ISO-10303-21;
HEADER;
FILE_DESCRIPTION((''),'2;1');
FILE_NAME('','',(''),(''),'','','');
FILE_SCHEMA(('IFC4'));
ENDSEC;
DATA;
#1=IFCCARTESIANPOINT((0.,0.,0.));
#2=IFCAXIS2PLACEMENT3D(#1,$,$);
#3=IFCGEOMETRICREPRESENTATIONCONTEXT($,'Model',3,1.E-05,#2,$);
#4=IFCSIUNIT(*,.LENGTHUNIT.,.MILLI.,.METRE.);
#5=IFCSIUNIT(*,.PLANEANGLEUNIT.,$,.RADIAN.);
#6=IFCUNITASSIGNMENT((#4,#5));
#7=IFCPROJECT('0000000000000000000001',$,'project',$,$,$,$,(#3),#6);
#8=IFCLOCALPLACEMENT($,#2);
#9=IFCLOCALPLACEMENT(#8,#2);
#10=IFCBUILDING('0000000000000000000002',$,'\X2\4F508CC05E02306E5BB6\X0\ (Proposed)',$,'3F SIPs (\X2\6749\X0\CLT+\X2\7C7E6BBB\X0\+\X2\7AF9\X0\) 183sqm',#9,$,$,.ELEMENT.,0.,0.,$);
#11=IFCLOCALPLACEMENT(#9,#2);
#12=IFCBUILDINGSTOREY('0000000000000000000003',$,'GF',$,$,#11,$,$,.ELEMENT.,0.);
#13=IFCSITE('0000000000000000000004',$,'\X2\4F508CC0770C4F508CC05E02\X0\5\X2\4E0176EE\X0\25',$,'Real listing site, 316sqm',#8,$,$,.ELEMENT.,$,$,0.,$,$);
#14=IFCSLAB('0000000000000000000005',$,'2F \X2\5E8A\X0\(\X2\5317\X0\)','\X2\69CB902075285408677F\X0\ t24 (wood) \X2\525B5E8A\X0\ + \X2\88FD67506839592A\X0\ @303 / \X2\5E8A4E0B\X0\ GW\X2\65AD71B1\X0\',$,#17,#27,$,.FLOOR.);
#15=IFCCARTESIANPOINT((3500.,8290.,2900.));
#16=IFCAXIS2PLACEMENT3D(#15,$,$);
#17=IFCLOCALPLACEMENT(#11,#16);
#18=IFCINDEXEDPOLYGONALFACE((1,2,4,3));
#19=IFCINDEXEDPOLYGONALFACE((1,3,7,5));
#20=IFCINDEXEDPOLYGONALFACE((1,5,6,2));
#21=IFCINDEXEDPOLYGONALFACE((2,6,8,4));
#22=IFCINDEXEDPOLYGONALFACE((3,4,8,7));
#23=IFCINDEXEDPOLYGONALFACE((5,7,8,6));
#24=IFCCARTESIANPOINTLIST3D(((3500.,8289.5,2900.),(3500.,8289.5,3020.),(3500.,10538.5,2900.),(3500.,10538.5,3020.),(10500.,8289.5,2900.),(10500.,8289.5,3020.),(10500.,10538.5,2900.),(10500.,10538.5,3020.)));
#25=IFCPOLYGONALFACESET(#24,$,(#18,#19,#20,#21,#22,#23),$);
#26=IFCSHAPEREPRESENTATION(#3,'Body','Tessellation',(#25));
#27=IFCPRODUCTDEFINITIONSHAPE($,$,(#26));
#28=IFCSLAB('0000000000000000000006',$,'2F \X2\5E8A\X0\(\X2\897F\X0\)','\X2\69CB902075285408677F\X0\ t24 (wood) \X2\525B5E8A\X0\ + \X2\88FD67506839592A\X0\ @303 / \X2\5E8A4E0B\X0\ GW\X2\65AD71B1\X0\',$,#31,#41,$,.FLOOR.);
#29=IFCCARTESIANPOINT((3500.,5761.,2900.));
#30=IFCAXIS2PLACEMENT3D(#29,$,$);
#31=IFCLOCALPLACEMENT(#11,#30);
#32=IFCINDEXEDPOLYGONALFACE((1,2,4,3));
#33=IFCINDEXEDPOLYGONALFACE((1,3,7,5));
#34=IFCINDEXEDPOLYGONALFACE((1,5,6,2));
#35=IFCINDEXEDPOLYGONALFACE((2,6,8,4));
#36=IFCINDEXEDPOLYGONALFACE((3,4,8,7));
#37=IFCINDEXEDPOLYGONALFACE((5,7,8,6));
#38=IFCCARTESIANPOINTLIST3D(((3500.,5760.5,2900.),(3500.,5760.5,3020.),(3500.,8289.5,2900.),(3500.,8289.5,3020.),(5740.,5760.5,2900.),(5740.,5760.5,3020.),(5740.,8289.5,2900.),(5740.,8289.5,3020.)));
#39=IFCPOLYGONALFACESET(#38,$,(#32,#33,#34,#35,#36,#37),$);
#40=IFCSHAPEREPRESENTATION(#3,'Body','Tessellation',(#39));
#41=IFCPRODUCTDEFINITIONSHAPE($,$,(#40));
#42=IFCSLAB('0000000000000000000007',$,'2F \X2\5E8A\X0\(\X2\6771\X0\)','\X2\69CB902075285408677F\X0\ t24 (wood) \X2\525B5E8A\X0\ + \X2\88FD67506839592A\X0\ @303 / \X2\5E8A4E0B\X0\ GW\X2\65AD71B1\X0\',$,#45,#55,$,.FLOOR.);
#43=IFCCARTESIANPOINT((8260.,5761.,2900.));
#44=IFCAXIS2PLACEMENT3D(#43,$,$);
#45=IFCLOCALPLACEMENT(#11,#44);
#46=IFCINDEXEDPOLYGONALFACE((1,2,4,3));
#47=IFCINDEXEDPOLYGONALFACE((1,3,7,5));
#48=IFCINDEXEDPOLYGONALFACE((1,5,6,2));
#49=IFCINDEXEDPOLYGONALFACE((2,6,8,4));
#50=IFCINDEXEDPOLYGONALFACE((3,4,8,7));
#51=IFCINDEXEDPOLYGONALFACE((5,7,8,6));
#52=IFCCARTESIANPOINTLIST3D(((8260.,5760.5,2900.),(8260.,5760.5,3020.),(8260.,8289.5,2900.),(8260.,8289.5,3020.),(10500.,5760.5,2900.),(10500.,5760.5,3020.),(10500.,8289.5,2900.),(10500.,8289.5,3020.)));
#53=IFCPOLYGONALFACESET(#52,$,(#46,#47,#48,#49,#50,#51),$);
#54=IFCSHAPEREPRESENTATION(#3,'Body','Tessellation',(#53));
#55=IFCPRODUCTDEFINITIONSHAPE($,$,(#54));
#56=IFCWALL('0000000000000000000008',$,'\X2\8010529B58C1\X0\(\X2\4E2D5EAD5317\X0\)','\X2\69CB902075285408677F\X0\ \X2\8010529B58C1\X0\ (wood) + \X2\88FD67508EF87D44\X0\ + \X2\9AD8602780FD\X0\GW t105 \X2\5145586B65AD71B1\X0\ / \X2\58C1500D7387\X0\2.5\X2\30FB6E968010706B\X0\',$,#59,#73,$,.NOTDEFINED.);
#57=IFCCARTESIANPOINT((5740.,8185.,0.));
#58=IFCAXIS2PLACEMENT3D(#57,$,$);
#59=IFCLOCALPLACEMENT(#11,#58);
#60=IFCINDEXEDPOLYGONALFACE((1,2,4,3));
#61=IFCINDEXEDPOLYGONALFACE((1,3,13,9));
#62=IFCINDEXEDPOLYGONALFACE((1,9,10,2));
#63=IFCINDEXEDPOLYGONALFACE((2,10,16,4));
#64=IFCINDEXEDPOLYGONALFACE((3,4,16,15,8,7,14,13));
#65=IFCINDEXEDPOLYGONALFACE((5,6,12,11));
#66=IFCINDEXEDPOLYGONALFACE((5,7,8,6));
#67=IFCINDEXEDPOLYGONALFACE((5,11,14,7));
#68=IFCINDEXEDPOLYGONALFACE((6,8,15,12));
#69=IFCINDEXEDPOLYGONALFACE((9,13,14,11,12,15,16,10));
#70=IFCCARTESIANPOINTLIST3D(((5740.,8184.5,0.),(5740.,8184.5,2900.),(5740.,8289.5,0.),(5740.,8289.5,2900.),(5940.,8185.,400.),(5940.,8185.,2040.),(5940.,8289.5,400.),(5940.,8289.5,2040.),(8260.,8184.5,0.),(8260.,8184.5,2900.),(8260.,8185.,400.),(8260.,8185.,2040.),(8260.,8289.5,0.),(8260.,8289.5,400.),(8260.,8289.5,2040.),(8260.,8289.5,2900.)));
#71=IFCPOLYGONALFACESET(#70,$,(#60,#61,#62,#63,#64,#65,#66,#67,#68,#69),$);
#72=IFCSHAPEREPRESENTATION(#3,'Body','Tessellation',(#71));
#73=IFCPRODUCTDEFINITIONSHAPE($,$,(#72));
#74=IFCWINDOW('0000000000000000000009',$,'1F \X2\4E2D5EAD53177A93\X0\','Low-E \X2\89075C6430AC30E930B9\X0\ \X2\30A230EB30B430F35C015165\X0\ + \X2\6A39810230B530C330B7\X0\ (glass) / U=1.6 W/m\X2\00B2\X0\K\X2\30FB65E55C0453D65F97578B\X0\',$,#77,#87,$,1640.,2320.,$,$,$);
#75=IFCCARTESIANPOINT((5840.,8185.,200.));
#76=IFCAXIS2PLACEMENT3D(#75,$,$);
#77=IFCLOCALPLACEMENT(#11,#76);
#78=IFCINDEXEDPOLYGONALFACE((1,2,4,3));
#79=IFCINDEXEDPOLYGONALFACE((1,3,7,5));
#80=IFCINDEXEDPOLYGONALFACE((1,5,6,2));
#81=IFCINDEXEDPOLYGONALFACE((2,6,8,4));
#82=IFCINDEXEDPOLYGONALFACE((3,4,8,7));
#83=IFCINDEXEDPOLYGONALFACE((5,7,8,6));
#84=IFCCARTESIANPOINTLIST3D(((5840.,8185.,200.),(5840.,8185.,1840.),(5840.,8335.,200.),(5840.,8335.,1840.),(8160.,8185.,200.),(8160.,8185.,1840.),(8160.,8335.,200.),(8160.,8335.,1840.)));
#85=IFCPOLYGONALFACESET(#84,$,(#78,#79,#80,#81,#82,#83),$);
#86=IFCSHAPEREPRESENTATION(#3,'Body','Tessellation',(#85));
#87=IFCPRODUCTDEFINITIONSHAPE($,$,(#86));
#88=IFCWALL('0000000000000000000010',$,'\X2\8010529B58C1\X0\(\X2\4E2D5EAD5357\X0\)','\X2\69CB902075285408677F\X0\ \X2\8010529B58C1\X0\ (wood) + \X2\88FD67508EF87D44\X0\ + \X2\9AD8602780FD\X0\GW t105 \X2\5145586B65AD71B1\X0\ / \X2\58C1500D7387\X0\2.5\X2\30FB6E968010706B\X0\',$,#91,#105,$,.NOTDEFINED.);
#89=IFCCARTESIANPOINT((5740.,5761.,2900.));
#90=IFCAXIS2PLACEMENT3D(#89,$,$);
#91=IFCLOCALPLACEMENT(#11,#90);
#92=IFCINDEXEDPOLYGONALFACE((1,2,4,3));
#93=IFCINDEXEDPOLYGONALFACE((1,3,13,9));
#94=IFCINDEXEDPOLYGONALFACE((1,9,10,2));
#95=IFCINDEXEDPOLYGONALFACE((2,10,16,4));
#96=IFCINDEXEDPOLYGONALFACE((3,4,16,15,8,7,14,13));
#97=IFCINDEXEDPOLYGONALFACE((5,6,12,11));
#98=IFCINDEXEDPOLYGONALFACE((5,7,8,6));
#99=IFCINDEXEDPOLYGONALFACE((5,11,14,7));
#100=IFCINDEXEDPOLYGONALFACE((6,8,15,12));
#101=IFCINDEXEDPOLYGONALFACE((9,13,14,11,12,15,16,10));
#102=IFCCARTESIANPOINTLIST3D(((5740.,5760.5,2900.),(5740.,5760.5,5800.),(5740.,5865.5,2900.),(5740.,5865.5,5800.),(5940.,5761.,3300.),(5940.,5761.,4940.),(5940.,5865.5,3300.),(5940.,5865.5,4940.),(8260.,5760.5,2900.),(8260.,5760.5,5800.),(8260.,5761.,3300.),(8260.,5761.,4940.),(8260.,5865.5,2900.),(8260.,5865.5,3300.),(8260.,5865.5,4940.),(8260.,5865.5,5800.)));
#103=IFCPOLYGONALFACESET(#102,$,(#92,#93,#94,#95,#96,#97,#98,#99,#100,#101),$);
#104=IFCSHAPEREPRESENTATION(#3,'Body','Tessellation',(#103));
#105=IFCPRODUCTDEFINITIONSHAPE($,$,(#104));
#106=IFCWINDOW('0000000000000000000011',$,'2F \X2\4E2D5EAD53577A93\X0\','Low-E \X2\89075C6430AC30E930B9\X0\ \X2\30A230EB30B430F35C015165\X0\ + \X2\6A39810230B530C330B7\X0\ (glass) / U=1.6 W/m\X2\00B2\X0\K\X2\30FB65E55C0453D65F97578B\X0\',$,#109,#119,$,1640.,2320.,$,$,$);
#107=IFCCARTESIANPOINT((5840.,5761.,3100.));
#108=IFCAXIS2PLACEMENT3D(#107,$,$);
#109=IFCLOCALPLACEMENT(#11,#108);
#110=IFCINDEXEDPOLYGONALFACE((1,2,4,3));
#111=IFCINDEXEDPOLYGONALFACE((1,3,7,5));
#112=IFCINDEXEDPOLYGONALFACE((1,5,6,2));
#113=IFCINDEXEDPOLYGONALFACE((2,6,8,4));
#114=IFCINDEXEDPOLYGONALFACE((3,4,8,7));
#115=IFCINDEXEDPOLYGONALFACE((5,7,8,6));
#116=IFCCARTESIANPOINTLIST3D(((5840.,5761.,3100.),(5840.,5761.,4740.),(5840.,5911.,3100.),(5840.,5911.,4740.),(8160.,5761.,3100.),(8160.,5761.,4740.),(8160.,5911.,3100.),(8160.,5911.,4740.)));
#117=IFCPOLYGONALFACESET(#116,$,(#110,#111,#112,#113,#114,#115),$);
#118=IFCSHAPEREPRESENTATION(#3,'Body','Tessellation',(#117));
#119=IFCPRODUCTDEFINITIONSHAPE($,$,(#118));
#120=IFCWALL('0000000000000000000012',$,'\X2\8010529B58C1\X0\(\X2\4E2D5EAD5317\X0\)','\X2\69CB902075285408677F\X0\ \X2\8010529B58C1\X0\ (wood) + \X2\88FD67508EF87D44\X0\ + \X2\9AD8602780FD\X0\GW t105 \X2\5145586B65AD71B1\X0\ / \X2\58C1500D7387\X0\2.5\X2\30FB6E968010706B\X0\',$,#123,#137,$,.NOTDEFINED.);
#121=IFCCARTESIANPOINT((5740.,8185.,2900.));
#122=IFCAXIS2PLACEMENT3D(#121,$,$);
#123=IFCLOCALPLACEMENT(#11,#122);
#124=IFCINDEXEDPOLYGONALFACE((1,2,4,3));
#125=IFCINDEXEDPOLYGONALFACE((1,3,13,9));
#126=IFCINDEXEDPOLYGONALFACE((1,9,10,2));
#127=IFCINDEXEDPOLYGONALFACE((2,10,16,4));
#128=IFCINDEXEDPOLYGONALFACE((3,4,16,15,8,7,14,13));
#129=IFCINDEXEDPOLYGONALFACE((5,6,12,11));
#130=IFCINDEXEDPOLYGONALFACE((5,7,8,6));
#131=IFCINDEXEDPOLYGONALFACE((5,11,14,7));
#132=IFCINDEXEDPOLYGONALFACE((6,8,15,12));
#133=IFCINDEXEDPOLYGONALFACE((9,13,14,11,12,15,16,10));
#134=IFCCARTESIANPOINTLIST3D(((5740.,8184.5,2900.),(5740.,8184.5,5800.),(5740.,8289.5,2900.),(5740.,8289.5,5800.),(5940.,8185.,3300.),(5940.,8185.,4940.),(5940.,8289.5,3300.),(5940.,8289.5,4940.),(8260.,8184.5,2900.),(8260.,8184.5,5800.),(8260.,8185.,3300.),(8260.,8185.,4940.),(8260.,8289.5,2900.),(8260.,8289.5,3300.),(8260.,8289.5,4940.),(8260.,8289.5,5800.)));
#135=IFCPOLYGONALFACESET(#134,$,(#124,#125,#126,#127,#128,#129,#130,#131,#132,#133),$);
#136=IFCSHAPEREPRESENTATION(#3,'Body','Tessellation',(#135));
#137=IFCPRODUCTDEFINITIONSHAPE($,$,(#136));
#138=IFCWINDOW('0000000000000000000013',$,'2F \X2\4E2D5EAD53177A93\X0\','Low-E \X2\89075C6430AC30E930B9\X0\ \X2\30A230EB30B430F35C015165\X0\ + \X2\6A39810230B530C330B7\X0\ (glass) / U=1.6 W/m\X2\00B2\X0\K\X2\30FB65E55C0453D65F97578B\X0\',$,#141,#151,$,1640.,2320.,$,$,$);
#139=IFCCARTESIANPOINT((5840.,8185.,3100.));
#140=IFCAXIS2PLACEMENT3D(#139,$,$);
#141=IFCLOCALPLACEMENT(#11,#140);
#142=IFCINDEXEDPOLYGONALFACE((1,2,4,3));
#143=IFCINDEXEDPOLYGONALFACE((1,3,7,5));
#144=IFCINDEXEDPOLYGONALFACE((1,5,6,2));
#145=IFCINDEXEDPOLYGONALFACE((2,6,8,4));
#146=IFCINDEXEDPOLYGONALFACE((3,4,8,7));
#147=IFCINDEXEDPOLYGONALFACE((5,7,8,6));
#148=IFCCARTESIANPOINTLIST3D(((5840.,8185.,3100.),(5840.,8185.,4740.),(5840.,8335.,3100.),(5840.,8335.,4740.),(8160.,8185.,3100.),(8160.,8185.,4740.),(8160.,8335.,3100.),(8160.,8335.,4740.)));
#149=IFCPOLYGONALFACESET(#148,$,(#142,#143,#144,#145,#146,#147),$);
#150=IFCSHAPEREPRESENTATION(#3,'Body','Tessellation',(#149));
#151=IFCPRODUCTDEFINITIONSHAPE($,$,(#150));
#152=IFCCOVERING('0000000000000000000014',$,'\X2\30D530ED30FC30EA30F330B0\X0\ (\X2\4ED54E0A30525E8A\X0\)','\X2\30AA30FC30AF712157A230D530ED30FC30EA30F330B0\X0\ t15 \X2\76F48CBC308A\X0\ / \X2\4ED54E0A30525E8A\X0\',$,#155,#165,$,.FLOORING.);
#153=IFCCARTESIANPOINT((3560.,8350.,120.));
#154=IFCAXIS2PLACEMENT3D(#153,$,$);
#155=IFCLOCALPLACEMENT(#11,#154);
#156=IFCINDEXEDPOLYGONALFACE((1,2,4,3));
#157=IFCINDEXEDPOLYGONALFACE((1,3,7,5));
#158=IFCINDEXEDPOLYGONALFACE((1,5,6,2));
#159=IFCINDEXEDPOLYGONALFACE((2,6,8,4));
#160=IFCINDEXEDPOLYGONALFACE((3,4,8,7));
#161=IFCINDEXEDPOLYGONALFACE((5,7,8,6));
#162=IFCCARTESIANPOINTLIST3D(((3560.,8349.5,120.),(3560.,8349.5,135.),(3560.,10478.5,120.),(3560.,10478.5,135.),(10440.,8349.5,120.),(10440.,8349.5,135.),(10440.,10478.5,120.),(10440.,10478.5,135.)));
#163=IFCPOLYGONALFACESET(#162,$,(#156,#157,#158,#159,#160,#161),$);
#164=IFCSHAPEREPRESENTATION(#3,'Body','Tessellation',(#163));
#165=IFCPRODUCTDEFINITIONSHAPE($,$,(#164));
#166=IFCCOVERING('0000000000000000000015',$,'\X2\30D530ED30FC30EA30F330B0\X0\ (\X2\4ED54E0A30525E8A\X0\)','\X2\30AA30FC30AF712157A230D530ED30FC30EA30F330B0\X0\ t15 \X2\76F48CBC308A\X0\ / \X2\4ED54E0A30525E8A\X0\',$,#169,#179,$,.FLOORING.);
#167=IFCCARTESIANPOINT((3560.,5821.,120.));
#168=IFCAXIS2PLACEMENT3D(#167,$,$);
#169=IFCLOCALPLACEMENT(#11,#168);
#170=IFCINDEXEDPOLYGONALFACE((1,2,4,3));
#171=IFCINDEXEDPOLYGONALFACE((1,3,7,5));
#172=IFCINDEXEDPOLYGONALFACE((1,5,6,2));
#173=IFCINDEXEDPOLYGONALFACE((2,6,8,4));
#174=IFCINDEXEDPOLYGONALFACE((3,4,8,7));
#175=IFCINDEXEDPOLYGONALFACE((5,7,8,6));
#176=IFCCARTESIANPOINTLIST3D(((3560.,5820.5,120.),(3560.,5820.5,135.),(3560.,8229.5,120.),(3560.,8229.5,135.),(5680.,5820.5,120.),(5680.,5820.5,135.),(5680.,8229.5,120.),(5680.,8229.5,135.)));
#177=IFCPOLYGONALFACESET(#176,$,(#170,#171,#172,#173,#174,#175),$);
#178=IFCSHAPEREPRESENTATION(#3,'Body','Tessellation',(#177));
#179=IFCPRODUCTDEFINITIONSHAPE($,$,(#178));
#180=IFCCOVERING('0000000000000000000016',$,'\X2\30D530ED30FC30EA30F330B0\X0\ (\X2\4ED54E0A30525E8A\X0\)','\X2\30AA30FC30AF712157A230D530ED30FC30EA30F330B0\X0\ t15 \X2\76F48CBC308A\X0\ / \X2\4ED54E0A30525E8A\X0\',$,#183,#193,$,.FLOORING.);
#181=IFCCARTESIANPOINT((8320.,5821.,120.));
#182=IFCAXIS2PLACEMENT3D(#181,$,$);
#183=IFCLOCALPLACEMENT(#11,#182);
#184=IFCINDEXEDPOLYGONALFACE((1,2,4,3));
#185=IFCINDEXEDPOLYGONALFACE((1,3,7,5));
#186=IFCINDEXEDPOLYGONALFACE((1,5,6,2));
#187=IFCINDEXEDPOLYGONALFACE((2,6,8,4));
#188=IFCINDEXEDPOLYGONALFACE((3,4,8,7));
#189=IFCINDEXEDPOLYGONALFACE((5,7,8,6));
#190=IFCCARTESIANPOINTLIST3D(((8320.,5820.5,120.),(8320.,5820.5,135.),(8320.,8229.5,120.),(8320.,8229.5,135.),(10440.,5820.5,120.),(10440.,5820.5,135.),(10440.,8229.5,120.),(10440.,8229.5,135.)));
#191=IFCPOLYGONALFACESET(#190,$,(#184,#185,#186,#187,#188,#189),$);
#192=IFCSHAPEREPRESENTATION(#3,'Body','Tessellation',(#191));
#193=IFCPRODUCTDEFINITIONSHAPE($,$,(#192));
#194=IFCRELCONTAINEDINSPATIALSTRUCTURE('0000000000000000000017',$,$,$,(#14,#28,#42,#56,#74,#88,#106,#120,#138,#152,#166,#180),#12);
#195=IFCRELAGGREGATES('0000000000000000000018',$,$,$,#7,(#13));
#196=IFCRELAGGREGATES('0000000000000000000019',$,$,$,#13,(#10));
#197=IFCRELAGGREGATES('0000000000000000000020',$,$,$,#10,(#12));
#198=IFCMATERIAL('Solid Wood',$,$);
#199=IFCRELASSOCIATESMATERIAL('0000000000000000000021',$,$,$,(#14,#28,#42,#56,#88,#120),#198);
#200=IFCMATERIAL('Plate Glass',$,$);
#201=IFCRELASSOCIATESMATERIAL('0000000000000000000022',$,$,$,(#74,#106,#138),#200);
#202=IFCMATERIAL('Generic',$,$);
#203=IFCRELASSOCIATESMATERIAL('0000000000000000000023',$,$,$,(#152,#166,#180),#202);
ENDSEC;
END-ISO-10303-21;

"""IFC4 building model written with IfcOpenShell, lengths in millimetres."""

from ifc_helpers import new_model, si_unit, frame, frame_2d, origin, place, context, project, spatial, rectangle, extrude, material, element, fill, save


model = new_model("IFC4")

# Units and contexts
model_context = context("Model", 3, precision=1e-05, world=origin())
ifc_project = project(units=[si_unit("LENGTHUNIT", "METRE", prefix="MILLI"), si_unit("PLANEANGLEUNIT", "RADIAN")], contexts=[model_context])

# Site, building, storey
site_placement = place(None, origin())
site = spatial("IfcSite", under=ifc_project, at=site_placement, Name="佐賀県佐賀市5丁目25", ObjectType="Real listing site, 316sqm", CompositionType="ELEMENT", RefElevation=0.0)
building_placement = place(site_placement, origin())
building = spatial("IfcBuilding", under=site, at=building_placement, Name="佐賀市の家 (Proposed)", ObjectType="3F SIPs (杉CLT+籾殻+竹) 183sqm", CompositionType="ELEMENT", ElevationOfRefHeight=0.0, ElevationOfTerrain=0.0)
storey_placement = place(building_placement, origin())
storey = spatial("IfcBuildingStorey", under=building, at=storey_placement, Name="GF", CompositionType="ELEMENT", Elevation=0.0)

# Slabs
ifc_material_1 = material(Name="Solid Wood")
slab_1_placement = place(storey_placement, frame((3500.0, 8290.0, 2900.0)))
element("IfcSlab", 1, at=slab_1_placement, inside=storey, material=ifc_material_1, Name="2F 床(北)", Description="構造用合板 t24 (wood) 剛床 + 製材根太 @303 / 床下 GW断熱", PredefinedType="FLOOR", context=model_context, shape_type="SweptSolid", body=[
    extrude(rectangle(XDim=7000.0, YDim=2249.0, at=frame_2d((3500.0, 1124.0))), frame((3500.0, 8290.0, 2900.0)), (0.0, 0.0, 1.0), 120.0),
])
slab_2_placement = place(storey_placement, frame((3500.0, 5761.0, 2900.0)))
element("IfcSlab", 2, at=slab_2_placement, inside=storey, material=ifc_material_1, Name="2F 床(西)", Description="構造用合板 t24 (wood) 剛床 + 製材根太 @303 / 床下 GW断熱", PredefinedType="FLOOR", context=model_context, shape_type="SweptSolid", body=[
    extrude(rectangle(XDim=2240.0, YDim=2529.0, at=frame_2d((1120.0, 1264.0))), frame((3500.0, 5761.0, 2900.0)), (0.0, 0.0, 1.0), 120.0),
])
slab_3_placement = place(storey_placement, frame((8260.0, 5761.0, 2900.0)))
element("IfcSlab", 3, at=slab_3_placement, inside=storey, material=ifc_material_1, Name="2F 床(東)", Description="構造用合板 t24 (wood) 剛床 + 製材根太 @303 / 床下 GW断熱", PredefinedType="FLOOR", context=model_context, shape_type="SweptSolid", body=[
    extrude(rectangle(XDim=2240.0, YDim=2529.0, at=frame_2d((1120.0, 1264.0))), frame((8260.0, 5761.0, 2900.0)), (0.0, 0.0, 1.0), 120.0),
])

# Wall, opening, window
wall_1_placement = place(storey_placement, frame((5740.0, 8185.0, 0.0)))
wall_1 = element("IfcWall", 4, at=wall_1_placement, inside=storey, material=ifc_material_1, Name="耐力壁(中庭北)", Description="構造用合板 耐力壁 (wood) + 製材軸組 + 高性能GW t105 充填断熱 / 壁倍率2.5・準耐火", PredefinedType="NOTDEFINED", context=model_context, shape_type="SweptSolid", body=[
    extrude(rectangle(XDim=2520.0, YDim=105.0, at=frame_2d((1260.0, 52.0))), frame((5740.0, 8185.0, 0.0)), (0.0, 0.0, 1.0), 2900.0),
])
opening_1_placement = place(storey_placement, frame((5840.0, 8185.0, 200.0)))
opening_1 = element("IfcOpeningElement", 5, at=opening_1_placement, cuts=wall_1, PredefinedType="NOTDEFINED", context=model_context, shape_type="SweptSolid", body=[
    extrude(rectangle(XDim=2320.0, YDim=150.0, at=frame_2d((1160.0, 75.0))), frame((5840.0, 8185.0, 200.0)), (0.0, 0.0, 1.0), 1640.0),
])
ifc_material_2 = material(Name="Plate Glass")
window_1_placement = place(storey_placement, frame((5840.0, 8185.0, 200.0)))
window_1 = element("IfcWindow", 6, at=window_1_placement, inside=storey, material=ifc_material_2, Name="1F 中庭北窓", Description="Low-E 複層ガラス アルゴン封入 + 樹脂サッシ (glass) / U=1.6 W/m²K・日射取得型", OverallHeight=1640.0, OverallWidth=2320.0, context=model_context, shape_type="SweptSolid", body=[
    extrude(rectangle(XDim=2320.0, YDim=150.0, at=frame_2d((1160.0, 75.0))), frame((5840.0, 8185.0, 200.0)), (0.0, 0.0, 1.0), 1640.0),
])
fill(opening_1, window_1)

# Walls, openings, windows
wall_2_placement = place(storey_placement, frame((5740.0, 5761.0, 2900.0)))
wall_2 = element("IfcWall", 7, at=wall_2_placement, inside=storey, material=ifc_material_1, Name="耐力壁(中庭南)", Description="構造用合板 耐力壁 (wood) + 製材軸組 + 高性能GW t105 充填断熱 / 壁倍率2.5・準耐火", PredefinedType="NOTDEFINED", context=model_context, shape_type="SweptSolid", body=[
    extrude(rectangle(XDim=2520.0, YDim=105.0, at=frame_2d((1260.0, 52.0))), frame((5740.0, 5761.0, 2900.0)), (0.0, 0.0, 1.0), 2900.0),
])
opening_2_placement = place(storey_placement, frame((5840.0, 5761.0, 3100.0)))
opening_2 = element("IfcOpeningElement", 8, at=opening_2_placement, cuts=wall_2, PredefinedType="NOTDEFINED", context=model_context, shape_type="SweptSolid", body=[
    extrude(rectangle(XDim=2320.0, YDim=150.0, at=frame_2d((1160.0, 75.0))), frame((5840.0, 5761.0, 3100.0)), (0.0, 0.0, 1.0), 1640.0),
])
window_2_placement = place(storey_placement, frame((5840.0, 5761.0, 3100.0)))
window_2 = element("IfcWindow", 9, at=window_2_placement, inside=storey, material=ifc_material_2, Name="2F 中庭南窓", Description="Low-E 複層ガラス アルゴン封入 + 樹脂サッシ (glass) / U=1.6 W/m²K・日射取得型", OverallHeight=1640.0, OverallWidth=2320.0, context=model_context, shape_type="SweptSolid", body=[
    extrude(rectangle(XDim=2320.0, YDim=150.0, at=frame_2d((1160.0, 75.0))), frame((5840.0, 5761.0, 3100.0)), (0.0, 0.0, 1.0), 1640.0),
])
fill(opening_2, window_2)
wall_3_placement = place(storey_placement, frame((5740.0, 8185.0, 2900.0)))
wall_3 = element("IfcWall", 10, at=wall_3_placement, inside=storey, material=ifc_material_1, Name="耐力壁(中庭北)", Description="構造用合板 耐力壁 (wood) + 製材軸組 + 高性能GW t105 充填断熱 / 壁倍率2.5・準耐火", PredefinedType="NOTDEFINED", context=model_context, shape_type="SweptSolid", body=[
    extrude(rectangle(XDim=2520.0, YDim=105.0, at=frame_2d((1260.0, 52.0))), frame((5740.0, 8185.0, 2900.0)), (0.0, 0.0, 1.0), 2900.0),
])
opening_3_placement = place(storey_placement, frame((5840.0, 8185.0, 3100.0)))
opening_3 = element("IfcOpeningElement", 11, at=opening_3_placement, cuts=wall_3, PredefinedType="NOTDEFINED", context=model_context, shape_type="SweptSolid", body=[
    extrude(rectangle(XDim=2320.0, YDim=150.0, at=frame_2d((1160.0, 75.0))), frame((5840.0, 8185.0, 3100.0)), (0.0, 0.0, 1.0), 1640.0),
])
window_3_placement = place(storey_placement, frame((5840.0, 8185.0, 3100.0)))
window_3 = element("IfcWindow", 12, at=window_3_placement, inside=storey, material=ifc_material_2, Name="2F 中庭北窓", Description="Low-E 複層ガラス アルゴン封入 + 樹脂サッシ (glass) / U=1.6 W/m²K・日射取得型", OverallHeight=1640.0, OverallWidth=2320.0, context=model_context, shape_type="SweptSolid", body=[
    extrude(rectangle(XDim=2320.0, YDim=150.0, at=frame_2d((1160.0, 75.0))), frame((5840.0, 8185.0, 3100.0)), (0.0, 0.0, 1.0), 1640.0),
])
fill(opening_3, window_3)

# Coverings
ifc_material_3 = material(Name="Generic")
covering_1_placement = place(storey_placement, frame((3560.0, 8350.0, 120.0)))
element("IfcCovering", 13, at=covering_1_placement, inside=storey, material=ifc_material_3, Name="フローリング (仕上げ床)", Description="オーク無垢フローリング t15 直貼り / 仕上げ床", PredefinedType="FLOORING", context=model_context, shape_type="SweptSolid", body=[
    extrude(rectangle(XDim=6880.0, YDim=2129.0, at=frame_2d((3440.0, 1064.0))), frame((3560.0, 8350.0, 120.0)), (0.0, 0.0, 1.0), 15.0),
])
covering_2_placement = place(storey_placement, frame((3560.0, 5821.0, 120.0)))
element("IfcCovering", 14, at=covering_2_placement, inside=storey, material=ifc_material_3, Name="フローリング (仕上げ床)", Description="オーク無垢フローリング t15 直貼り / 仕上げ床", PredefinedType="FLOORING", context=model_context, shape_type="SweptSolid", body=[
    extrude(rectangle(XDim=2120.0, YDim=2409.0, at=frame_2d((1060.0, 1204.0))), frame((3560.0, 5821.0, 120.0)), (0.0, 0.0, 1.0), 15.0),
])
covering_3_placement = place(storey_placement, frame((8320.0, 5821.0, 120.0)))
element("IfcCovering", 15, at=covering_3_placement, inside=storey, material=ifc_material_3, Name="フローリング (仕上げ床)", Description="オーク無垢フローリング t15 直貼り / 仕上げ床", PredefinedType="FLOORING", context=model_context, shape_type="SweptSolid", body=[
    extrude(rectangle(XDim=2120.0, YDim=2409.0, at=frame_2d((1060.0, 1204.0))), frame((8320.0, 5821.0, 120.0)), (0.0, 0.0, 1.0), 15.0),
])

save(model, "model.ifc")
